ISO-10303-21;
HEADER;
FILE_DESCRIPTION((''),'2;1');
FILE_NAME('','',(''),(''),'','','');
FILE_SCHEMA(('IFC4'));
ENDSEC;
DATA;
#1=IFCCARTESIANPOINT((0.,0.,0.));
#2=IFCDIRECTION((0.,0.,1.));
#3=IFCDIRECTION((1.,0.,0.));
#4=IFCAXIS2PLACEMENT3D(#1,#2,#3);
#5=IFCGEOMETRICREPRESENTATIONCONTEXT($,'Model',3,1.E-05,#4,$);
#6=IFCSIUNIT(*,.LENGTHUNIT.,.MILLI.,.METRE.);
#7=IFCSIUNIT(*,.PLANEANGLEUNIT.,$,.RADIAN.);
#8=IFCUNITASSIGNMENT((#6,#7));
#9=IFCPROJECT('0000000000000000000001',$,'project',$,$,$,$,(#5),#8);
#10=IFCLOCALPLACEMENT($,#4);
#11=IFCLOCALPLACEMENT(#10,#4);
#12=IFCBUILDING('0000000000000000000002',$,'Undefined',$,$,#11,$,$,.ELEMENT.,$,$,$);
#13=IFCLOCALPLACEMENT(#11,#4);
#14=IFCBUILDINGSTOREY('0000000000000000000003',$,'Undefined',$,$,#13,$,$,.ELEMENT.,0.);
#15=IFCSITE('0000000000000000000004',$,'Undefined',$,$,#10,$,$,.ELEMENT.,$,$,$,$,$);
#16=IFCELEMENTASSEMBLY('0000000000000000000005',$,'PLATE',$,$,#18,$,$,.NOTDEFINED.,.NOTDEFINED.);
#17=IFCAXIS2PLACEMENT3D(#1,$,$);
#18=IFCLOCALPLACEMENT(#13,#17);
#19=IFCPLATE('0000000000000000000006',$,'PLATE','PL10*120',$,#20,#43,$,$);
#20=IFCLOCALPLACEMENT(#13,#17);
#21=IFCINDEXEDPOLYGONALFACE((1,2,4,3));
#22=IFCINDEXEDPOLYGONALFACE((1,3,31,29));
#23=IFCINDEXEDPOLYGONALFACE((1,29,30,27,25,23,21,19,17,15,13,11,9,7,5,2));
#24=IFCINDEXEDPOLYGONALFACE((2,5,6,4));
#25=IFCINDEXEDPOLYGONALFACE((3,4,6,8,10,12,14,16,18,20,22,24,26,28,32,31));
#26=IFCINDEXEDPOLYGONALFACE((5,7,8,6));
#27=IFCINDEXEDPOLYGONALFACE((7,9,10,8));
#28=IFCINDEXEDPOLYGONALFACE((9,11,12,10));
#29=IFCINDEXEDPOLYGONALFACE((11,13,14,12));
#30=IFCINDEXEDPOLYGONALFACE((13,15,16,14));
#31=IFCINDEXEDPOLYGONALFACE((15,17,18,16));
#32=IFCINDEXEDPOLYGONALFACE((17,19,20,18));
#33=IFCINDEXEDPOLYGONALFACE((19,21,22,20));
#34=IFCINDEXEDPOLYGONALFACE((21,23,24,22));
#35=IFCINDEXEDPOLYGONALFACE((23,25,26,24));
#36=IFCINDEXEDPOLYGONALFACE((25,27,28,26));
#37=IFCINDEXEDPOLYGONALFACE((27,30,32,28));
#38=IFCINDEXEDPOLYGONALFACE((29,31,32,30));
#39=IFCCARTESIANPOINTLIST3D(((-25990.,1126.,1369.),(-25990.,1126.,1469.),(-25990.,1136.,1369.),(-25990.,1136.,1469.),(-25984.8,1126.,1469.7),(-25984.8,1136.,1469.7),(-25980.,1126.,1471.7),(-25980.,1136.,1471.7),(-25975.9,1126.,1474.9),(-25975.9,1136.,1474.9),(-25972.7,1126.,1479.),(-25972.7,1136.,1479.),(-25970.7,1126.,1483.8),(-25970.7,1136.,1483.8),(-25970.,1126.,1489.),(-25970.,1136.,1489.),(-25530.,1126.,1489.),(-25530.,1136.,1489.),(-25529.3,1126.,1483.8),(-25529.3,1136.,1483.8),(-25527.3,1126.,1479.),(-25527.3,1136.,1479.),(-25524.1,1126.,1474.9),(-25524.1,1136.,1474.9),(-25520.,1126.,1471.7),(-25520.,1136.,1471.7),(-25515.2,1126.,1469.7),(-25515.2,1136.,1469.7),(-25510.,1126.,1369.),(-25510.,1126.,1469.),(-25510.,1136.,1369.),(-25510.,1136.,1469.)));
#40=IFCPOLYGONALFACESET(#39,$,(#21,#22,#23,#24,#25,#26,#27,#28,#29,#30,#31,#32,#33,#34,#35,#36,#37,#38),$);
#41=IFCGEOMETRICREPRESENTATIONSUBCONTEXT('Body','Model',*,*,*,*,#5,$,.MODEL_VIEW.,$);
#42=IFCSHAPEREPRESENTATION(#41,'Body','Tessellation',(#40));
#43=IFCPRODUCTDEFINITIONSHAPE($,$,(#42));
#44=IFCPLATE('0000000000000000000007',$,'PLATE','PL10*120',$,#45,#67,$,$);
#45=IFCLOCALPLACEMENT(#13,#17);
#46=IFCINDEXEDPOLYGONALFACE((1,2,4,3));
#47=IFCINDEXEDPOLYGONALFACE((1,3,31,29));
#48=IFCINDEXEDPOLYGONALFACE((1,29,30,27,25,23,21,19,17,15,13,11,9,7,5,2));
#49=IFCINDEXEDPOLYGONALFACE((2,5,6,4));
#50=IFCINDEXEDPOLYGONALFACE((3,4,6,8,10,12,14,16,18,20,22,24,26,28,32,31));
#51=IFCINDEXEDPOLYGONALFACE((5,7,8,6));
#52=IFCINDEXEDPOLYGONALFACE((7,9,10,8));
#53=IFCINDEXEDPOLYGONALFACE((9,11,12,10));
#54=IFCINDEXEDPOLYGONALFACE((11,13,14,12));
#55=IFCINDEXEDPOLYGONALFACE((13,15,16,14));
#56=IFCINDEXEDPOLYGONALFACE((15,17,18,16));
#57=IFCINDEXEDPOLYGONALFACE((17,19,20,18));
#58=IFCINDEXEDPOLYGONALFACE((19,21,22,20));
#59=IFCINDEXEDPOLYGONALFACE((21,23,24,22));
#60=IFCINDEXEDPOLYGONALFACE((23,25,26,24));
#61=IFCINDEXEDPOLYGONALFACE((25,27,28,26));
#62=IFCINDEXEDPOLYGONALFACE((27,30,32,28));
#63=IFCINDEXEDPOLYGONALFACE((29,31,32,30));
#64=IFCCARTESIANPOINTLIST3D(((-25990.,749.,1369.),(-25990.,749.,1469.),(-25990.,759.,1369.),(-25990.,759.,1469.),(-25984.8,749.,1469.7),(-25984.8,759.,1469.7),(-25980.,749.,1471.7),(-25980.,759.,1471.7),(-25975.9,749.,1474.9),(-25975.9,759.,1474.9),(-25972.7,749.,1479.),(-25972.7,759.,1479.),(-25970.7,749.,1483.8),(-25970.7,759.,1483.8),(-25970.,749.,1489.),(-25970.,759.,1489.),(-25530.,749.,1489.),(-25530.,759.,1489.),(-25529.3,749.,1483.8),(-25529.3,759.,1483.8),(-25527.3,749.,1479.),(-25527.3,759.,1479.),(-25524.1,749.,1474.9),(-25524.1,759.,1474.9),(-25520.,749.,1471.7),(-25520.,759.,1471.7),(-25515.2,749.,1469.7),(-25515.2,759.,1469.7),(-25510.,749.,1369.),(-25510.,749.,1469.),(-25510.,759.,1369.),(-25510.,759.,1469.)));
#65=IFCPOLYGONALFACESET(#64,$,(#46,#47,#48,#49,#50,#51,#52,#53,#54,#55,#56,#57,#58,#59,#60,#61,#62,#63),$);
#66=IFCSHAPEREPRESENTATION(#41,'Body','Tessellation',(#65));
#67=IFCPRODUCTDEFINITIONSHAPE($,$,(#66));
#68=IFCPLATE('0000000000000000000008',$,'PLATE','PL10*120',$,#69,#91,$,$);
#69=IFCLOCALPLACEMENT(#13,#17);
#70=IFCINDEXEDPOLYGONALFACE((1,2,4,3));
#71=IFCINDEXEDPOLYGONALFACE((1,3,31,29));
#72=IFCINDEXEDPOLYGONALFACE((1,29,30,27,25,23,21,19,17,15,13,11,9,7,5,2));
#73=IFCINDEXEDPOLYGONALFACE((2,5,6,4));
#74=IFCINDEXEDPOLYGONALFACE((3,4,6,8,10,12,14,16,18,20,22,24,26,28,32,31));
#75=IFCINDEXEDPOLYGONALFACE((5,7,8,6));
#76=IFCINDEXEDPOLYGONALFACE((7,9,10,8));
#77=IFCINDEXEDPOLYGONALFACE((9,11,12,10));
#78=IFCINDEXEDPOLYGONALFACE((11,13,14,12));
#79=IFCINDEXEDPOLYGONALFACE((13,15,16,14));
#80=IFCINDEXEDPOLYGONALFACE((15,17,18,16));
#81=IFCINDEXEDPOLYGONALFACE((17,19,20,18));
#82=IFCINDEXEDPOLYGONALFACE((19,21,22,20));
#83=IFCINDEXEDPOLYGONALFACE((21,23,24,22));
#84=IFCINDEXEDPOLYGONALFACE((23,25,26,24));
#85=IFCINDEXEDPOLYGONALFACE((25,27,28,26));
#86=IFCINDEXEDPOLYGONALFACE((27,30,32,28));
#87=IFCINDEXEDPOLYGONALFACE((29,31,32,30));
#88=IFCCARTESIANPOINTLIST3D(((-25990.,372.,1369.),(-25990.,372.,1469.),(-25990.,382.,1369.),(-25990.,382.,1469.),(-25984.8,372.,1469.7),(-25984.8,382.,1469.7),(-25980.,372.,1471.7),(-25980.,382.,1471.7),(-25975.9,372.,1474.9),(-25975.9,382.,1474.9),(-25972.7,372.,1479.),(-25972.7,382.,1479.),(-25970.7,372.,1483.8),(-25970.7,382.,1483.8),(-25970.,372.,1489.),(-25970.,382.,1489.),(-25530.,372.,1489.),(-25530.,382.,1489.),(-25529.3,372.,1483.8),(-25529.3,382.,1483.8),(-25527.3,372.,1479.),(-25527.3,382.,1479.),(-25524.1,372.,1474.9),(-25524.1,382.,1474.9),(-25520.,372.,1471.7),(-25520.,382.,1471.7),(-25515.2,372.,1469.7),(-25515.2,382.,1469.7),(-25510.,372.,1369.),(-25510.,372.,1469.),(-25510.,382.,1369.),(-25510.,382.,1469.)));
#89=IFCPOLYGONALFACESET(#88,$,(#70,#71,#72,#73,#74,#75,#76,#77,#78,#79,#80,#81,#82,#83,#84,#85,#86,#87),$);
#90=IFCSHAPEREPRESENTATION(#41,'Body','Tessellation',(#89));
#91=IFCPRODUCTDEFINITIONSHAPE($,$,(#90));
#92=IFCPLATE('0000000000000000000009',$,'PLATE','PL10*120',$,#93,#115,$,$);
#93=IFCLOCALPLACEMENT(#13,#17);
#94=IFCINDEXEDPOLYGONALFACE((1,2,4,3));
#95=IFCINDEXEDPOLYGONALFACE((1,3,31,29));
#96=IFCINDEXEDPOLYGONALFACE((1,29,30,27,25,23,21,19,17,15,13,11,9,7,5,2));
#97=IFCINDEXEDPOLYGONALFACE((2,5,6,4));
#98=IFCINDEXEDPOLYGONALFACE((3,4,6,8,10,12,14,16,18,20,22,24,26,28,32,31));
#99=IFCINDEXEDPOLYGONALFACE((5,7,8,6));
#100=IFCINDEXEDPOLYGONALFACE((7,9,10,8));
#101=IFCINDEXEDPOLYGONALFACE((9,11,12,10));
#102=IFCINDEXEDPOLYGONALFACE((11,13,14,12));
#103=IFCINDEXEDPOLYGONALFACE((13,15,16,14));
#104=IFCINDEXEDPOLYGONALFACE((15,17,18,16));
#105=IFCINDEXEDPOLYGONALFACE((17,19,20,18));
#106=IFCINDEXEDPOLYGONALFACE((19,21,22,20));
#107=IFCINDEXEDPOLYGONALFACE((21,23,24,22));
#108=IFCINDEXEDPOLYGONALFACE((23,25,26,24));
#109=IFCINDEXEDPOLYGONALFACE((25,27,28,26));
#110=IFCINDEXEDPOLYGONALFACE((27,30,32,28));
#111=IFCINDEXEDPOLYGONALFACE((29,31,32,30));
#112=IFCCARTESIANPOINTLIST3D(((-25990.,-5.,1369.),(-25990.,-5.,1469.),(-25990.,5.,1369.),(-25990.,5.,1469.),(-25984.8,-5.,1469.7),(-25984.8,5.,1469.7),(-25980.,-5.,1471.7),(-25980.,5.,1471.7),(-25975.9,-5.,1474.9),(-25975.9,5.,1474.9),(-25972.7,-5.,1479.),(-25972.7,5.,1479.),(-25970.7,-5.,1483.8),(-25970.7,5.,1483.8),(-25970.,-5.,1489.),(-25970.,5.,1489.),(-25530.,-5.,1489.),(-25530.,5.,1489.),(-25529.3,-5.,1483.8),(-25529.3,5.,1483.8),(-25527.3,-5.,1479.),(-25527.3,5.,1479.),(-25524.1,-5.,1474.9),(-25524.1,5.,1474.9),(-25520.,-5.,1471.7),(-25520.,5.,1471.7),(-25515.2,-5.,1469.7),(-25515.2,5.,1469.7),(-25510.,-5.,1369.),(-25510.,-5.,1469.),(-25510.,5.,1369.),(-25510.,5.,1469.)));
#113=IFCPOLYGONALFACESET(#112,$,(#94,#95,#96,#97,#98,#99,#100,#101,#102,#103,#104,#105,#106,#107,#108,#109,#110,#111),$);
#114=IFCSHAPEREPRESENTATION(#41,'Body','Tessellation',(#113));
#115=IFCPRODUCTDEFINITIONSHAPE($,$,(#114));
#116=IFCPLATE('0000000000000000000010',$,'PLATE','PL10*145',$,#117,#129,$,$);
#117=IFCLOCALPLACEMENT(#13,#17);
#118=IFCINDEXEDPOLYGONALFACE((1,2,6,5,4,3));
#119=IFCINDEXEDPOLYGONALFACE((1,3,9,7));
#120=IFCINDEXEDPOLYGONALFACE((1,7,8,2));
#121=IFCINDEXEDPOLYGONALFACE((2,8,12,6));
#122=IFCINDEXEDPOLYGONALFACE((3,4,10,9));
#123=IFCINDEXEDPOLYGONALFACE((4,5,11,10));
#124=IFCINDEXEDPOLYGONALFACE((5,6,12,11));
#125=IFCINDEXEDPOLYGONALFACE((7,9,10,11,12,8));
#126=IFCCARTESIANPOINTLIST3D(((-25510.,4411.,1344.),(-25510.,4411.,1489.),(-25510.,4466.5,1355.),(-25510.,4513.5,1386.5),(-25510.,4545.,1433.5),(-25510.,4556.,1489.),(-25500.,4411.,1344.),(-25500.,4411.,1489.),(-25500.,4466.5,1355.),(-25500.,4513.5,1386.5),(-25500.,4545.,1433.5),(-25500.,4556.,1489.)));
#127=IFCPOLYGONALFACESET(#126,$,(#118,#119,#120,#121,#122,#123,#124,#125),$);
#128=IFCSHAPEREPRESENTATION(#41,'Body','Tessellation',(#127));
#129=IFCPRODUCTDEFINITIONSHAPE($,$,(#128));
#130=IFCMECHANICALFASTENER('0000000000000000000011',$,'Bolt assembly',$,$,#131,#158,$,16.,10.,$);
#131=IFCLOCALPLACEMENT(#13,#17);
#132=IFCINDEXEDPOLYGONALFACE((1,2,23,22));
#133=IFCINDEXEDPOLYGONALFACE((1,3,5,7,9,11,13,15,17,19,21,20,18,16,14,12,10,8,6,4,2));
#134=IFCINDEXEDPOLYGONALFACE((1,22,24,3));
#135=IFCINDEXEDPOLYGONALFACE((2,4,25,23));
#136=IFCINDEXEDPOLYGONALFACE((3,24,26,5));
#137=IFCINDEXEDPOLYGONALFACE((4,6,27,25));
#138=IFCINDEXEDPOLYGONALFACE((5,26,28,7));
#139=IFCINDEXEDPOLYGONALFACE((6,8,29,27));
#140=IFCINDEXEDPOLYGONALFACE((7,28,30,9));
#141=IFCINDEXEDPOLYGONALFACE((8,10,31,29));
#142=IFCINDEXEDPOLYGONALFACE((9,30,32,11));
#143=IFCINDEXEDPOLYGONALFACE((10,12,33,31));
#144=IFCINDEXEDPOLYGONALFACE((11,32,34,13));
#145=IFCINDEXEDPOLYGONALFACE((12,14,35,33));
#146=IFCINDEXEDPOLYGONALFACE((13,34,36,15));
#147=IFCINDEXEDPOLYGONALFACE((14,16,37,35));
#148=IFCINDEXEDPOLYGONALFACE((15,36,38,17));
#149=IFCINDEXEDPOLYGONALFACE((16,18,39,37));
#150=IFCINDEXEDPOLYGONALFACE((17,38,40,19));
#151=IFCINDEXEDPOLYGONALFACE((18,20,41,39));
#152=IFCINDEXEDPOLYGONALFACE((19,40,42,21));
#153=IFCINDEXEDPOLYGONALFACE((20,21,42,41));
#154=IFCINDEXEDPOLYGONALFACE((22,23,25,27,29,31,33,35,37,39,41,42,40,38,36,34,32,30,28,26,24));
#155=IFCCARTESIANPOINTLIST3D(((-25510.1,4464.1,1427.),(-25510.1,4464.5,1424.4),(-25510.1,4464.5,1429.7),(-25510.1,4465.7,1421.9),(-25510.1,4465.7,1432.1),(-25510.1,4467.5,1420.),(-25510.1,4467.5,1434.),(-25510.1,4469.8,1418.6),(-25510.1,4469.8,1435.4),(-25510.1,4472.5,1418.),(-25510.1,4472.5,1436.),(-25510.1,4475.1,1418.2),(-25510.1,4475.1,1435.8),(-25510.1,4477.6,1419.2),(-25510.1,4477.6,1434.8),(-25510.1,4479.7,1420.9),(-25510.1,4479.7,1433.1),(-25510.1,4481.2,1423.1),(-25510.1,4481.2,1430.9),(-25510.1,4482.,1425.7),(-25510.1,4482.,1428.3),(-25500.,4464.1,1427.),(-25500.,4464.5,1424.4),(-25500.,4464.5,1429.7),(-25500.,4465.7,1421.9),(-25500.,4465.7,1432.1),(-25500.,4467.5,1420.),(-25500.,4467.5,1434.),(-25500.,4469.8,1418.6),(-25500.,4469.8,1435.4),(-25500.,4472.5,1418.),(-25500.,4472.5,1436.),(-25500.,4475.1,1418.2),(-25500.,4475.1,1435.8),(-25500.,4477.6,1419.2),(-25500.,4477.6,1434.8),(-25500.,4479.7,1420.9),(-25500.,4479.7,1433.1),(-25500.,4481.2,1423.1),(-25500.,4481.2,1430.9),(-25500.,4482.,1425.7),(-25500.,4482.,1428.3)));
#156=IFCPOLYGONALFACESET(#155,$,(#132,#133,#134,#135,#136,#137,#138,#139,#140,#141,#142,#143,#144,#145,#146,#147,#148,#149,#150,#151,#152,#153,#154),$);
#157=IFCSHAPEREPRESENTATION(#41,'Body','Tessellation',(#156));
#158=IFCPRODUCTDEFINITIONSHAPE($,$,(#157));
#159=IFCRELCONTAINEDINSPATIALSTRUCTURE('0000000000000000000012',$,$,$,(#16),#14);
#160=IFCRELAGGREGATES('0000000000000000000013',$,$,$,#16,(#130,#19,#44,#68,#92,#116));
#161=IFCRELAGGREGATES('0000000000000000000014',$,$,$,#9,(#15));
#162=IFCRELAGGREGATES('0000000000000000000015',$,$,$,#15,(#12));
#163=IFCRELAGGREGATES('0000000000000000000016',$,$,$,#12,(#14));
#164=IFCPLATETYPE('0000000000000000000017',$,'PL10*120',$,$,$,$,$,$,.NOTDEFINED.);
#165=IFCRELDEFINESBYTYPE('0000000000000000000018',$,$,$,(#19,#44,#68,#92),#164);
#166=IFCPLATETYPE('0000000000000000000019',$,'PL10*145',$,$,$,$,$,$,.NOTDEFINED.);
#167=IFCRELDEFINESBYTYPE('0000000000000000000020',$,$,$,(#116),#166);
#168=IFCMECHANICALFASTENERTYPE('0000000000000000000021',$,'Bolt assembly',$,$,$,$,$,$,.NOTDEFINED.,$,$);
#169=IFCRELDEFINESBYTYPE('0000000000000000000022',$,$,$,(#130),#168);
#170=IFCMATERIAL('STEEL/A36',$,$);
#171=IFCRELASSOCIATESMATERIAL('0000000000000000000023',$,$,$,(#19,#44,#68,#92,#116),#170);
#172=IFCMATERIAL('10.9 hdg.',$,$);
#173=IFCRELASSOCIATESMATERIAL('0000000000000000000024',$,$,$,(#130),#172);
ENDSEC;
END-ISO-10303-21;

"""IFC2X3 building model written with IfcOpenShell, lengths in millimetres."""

from ifc_helpers import new_model, si_unit, frame, frame_2d, origin_with_axes, origin_2d_with_axis, place, context, subcontext, project, spatial, polyline, circle_curve, parameter, trimmed, segment, composite_curve, circle, outline, extrude, source, transform, mapped, material, type_object, element, aggregate, save


model = new_model("IFC2X3")

# Units and contexts
model_context = context("Model", 3, precision=1e-05, world=origin_with_axes())
body_context = subcontext(model_context, "Body", "Model", "MODEL_VIEW")
ifc_project = project(units=[si_unit("LENGTHUNIT", "METRE", prefix="MILLI"), si_unit("PLANEANGLEUNIT", "RADIAN")], contexts=[model_context])

# Site, building, storey
site_placement = place(None, origin_with_axes())
site = spatial("IfcSite", under=ifc_project, at=site_placement, Name="Undefined", CompositionType="ELEMENT")
building_placement = place(site_placement, origin_with_axes())
building = spatial("IfcBuilding", under=site, at=building_placement, Name="Undefined", CompositionType="ELEMENT")
storey_placement = place(building_placement, origin_with_axes())
storey = spatial("IfcBuildingStorey", under=building, at=storey_placement, Name="Undefined", CompositionType="ELEMENT", Elevation=0.0)

# Element assembly, plates
assembly_1_placement = place(storey_placement, origin_with_axes())
assembly_1 = element("IfcElementAssembly", 1, at=assembly_1_placement, inside=storey, Name="PLATE", AssemblyPlace="NOTDEFINED", PredefinedType="NOTDEFINED")
ifc_material_1 = material(Name="STEEL/A36")
plate_type_1 = type_object("IfcPlateType", Name="PL10*120", PredefinedType="NOTDEFINED")
plate_1_placement = place(assembly_1_placement, frame((-25510.0, 1131.0, 1369.0), z_axis=(0.0, 1.0, 0.0), x_axis=(-1.0, 0.0, 0.0)))
plate_1 = element("IfcPlate", 2, at=plate_1_placement, type_object=plate_type_1, material=ifc_material_1, Name="PLATE", Description="PL10*120", context=body_context, shape_type="SweptSolid", body=[
    extrude(outline(composite_curve([segment(polyline([(0.0, 0.0), (480.0, 0.0), (480.0, 100.0)]), True, "CONTINUOUS"), segment(trimmed(circle_curve(frame_2d((480.0, 120.0), x_axis=(-0.000015, -1.0)), 20.0), [parameter(0.0)], [parameter(4.712402)], False, "PARAMETER"), True, "CONTINUOUS"), segment(polyline([(460.0, 120.0), (20.0, 120.0)]), True, "CONTINUOUS"), segment(trimmed(circle_curve(frame_2d((0.0, 120.0), x_axis=(1.0, -0.000002)), 20.0), [parameter(0.0)], [parameter(4.712393)], False, "PARAMETER"), True, "CONTINUOUS"), segment(polyline([(0.0, 100.0), (0.0, 0.0)]), True, "CONTINUOUS")], self_intersect=True)), frame((0.0, 0.0, -5.0), z_axis=(0.0, 0.0, 1.0), x_axis=(1.0, 0.0, 0.0)), (0.0, 0.0, 1.0), 10.0),
])
plate_2_placement = place(assembly_1_placement, frame((-25510.0, 754.0, 1369.0), z_axis=(0.0, 1.0, 0.0), x_axis=(-1.0, 0.0, 0.0)))
plate_2 = element("IfcPlate", 3, at=plate_2_placement, type_object=plate_type_1, material=ifc_material_1, Name="PLATE", Description="PL10*120", context=body_context, shape_type="SweptSolid", body=[
    extrude(outline(composite_curve([segment(polyline([(0.0, 0.0), (480.0, 0.0), (480.0, 100.0)]), True, "CONTINUOUS"), segment(trimmed(circle_curve(frame_2d((480.0, 120.0), x_axis=(-0.000015, -1.0)), 20.0), [parameter(0.0)], [parameter(4.712402)], False, "PARAMETER"), True, "CONTINUOUS"), segment(polyline([(460.0, 120.0), (20.0, 120.0)]), True, "CONTINUOUS"), segment(trimmed(circle_curve(frame_2d((0.0, 120.0), x_axis=(1.0, -0.000002)), 20.0), [parameter(0.0)], [parameter(4.712393)], False, "PARAMETER"), True, "CONTINUOUS"), segment(polyline([(0.0, 100.0), (0.0, 0.0)]), True, "CONTINUOUS")], self_intersect=True)), frame((0.0, 0.0, -5.0), z_axis=(0.0, 0.0, 1.0), x_axis=(1.0, 0.0, 0.0)), (0.0, 0.0, 1.0), 10.0),
])
plate_3_placement = place(assembly_1_placement, frame((-25510.0, 377.0, 1369.0), z_axis=(0.0, 1.0, 0.0), x_axis=(-1.0, 0.0, 0.0)))
plate_3 = element("IfcPlate", 4, at=plate_3_placement, type_object=plate_type_1, material=ifc_material_1, Name="PLATE", Description="PL10*120", context=body_context, shape_type="SweptSolid", body=[
    extrude(outline(composite_curve([segment(polyline([(0.0, 0.0), (480.0, 0.0), (480.0, 100.0)]), True, "CONTINUOUS"), segment(trimmed(circle_curve(frame_2d((480.0, 120.0), x_axis=(-0.000015, -1.0)), 20.0), [parameter(0.0)], [parameter(4.712402)], False, "PARAMETER"), True, "CONTINUOUS"), segment(polyline([(460.0, 120.0), (20.0, 120.0)]), True, "CONTINUOUS"), segment(trimmed(circle_curve(frame_2d((0.0, 120.0), x_axis=(1.0, -0.000002)), 20.0), [parameter(0.0)], [parameter(4.712393)], False, "PARAMETER"), True, "CONTINUOUS"), segment(polyline([(0.0, 100.0), (0.0, 0.0)]), True, "CONTINUOUS")], self_intersect=True)), frame((0.0, 0.0, -5.0), z_axis=(0.0, 0.0, 1.0), x_axis=(1.0, 0.0, 0.0)), (0.0, 0.0, 1.0), 10.0),
])
plate_4_placement = place(assembly_1_placement, frame((-25510.0, 0.0, 1369.0), z_axis=(0.0, 1.0, 0.0), x_axis=(-1.0, 0.0, 0.0)))
plate_4 = element("IfcPlate", 5, at=plate_4_placement, type_object=plate_type_1, material=ifc_material_1, Name="PLATE", Description="PL10*120", context=body_context, shape_type="SweptSolid", body=[
    extrude(outline(composite_curve([segment(polyline([(0.0, 0.0), (480.0, 0.0), (480.0, 100.0)]), True, "CONTINUOUS"), segment(trimmed(circle_curve(frame_2d((480.0, 120.0), x_axis=(-0.000015, -1.0)), 20.0), [parameter(0.0)], [parameter(4.712402)], False, "PARAMETER"), True, "CONTINUOUS"), segment(polyline([(460.0, 120.0), (20.0, 120.0)]), True, "CONTINUOUS"), segment(trimmed(circle_curve(frame_2d((0.0, 120.0), x_axis=(1.0, -0.000002)), 20.0), [parameter(0.0)], [parameter(4.712393)], False, "PARAMETER"), True, "CONTINUOUS"), segment(polyline([(0.0, 100.0), (0.0, 0.0)]), True, "CONTINUOUS")], self_intersect=True)), frame((0.0, 0.0, -5.0), z_axis=(0.0, 0.0, 1.0), x_axis=(1.0, 0.0, 0.0)), (0.0, 0.0, 1.0), 10.0),
])

# Plate
plate_type_2 = type_object("IfcPlateType", Name="PL10*145", PredefinedType="NOTDEFINED")
plate_5_placement = place(assembly_1_placement, frame((-25505.0, 4411.0, 1344.0), z_axis=(-1.0, 0.0, 0.0), x_axis=(0.0, 0.0, 1.0)))
plate_5 = element("IfcPlate", 6, at=plate_5_placement, type_object=plate_type_2, material=ifc_material_1, Name="PLATE", Description="PL10*145", context=body_context, shape_type="SweptSolid", body=[
    extrude(outline(polyline([(0.0, 0.0), (145.0, 0.0), (145.0, 145.0), (145.0, 145.0), (89.5, 134.0), (42.5, 102.5), (11.0, 55.5), (0.0, 0.0), (0.0, 0.0)])), frame((0.0, 0.0, -5.0), z_axis=(0.0, 0.0, 1.0), x_axis=(1.0, 0.0, 0.0)), (0.0, 0.0, 1.0), 10.0),
])

# Mechanical fastener
ifc_material_2 = material(Name="10.9 hdg.")
mechanical_fastener_type = type_object("IfcMechanicalFastenerType", Name="Bolt assembly")
shared_shape_1 = source(origin_with_axes(), body_context, "Body", "SweptSolid", [
    extrude(circle(Radius=9.0, at=origin_2d_with_axis()), frame((0.0, 0.0, 0.0), z_axis=(0.0, 1.0, 0.0), x_axis=(1.0, 0.0, 0.0)), (0.0, 0.0, 1.0), 10.1),
])
mechanical_fastener_1_placement = place(assembly_1_placement, frame((-25500.0, 4473.1, 1427.0), z_axis=(0.0, 0.0, -1.0), x_axis=(0.0, -1.0, 0.0)))
mechanical_fastener_1 = element("IfcMechanicalFastener", 7, at=mechanical_fastener_1_placement, type_object=mechanical_fastener_type, material=ifc_material_2, Name="Bolt assembly", NominalDiameter=16.0, NominalLength=10.0, context=body_context, shape_type="MappedRepresentation", body=[
    mapped(shared_shape_1, transform((0.0, 0.0, 0.0))),
])
aggregate(assembly_1, [mechanical_fastener_1, plate_1, plate_2, plate_3, plate_4, plate_5])

save(model, "model.ifc")
